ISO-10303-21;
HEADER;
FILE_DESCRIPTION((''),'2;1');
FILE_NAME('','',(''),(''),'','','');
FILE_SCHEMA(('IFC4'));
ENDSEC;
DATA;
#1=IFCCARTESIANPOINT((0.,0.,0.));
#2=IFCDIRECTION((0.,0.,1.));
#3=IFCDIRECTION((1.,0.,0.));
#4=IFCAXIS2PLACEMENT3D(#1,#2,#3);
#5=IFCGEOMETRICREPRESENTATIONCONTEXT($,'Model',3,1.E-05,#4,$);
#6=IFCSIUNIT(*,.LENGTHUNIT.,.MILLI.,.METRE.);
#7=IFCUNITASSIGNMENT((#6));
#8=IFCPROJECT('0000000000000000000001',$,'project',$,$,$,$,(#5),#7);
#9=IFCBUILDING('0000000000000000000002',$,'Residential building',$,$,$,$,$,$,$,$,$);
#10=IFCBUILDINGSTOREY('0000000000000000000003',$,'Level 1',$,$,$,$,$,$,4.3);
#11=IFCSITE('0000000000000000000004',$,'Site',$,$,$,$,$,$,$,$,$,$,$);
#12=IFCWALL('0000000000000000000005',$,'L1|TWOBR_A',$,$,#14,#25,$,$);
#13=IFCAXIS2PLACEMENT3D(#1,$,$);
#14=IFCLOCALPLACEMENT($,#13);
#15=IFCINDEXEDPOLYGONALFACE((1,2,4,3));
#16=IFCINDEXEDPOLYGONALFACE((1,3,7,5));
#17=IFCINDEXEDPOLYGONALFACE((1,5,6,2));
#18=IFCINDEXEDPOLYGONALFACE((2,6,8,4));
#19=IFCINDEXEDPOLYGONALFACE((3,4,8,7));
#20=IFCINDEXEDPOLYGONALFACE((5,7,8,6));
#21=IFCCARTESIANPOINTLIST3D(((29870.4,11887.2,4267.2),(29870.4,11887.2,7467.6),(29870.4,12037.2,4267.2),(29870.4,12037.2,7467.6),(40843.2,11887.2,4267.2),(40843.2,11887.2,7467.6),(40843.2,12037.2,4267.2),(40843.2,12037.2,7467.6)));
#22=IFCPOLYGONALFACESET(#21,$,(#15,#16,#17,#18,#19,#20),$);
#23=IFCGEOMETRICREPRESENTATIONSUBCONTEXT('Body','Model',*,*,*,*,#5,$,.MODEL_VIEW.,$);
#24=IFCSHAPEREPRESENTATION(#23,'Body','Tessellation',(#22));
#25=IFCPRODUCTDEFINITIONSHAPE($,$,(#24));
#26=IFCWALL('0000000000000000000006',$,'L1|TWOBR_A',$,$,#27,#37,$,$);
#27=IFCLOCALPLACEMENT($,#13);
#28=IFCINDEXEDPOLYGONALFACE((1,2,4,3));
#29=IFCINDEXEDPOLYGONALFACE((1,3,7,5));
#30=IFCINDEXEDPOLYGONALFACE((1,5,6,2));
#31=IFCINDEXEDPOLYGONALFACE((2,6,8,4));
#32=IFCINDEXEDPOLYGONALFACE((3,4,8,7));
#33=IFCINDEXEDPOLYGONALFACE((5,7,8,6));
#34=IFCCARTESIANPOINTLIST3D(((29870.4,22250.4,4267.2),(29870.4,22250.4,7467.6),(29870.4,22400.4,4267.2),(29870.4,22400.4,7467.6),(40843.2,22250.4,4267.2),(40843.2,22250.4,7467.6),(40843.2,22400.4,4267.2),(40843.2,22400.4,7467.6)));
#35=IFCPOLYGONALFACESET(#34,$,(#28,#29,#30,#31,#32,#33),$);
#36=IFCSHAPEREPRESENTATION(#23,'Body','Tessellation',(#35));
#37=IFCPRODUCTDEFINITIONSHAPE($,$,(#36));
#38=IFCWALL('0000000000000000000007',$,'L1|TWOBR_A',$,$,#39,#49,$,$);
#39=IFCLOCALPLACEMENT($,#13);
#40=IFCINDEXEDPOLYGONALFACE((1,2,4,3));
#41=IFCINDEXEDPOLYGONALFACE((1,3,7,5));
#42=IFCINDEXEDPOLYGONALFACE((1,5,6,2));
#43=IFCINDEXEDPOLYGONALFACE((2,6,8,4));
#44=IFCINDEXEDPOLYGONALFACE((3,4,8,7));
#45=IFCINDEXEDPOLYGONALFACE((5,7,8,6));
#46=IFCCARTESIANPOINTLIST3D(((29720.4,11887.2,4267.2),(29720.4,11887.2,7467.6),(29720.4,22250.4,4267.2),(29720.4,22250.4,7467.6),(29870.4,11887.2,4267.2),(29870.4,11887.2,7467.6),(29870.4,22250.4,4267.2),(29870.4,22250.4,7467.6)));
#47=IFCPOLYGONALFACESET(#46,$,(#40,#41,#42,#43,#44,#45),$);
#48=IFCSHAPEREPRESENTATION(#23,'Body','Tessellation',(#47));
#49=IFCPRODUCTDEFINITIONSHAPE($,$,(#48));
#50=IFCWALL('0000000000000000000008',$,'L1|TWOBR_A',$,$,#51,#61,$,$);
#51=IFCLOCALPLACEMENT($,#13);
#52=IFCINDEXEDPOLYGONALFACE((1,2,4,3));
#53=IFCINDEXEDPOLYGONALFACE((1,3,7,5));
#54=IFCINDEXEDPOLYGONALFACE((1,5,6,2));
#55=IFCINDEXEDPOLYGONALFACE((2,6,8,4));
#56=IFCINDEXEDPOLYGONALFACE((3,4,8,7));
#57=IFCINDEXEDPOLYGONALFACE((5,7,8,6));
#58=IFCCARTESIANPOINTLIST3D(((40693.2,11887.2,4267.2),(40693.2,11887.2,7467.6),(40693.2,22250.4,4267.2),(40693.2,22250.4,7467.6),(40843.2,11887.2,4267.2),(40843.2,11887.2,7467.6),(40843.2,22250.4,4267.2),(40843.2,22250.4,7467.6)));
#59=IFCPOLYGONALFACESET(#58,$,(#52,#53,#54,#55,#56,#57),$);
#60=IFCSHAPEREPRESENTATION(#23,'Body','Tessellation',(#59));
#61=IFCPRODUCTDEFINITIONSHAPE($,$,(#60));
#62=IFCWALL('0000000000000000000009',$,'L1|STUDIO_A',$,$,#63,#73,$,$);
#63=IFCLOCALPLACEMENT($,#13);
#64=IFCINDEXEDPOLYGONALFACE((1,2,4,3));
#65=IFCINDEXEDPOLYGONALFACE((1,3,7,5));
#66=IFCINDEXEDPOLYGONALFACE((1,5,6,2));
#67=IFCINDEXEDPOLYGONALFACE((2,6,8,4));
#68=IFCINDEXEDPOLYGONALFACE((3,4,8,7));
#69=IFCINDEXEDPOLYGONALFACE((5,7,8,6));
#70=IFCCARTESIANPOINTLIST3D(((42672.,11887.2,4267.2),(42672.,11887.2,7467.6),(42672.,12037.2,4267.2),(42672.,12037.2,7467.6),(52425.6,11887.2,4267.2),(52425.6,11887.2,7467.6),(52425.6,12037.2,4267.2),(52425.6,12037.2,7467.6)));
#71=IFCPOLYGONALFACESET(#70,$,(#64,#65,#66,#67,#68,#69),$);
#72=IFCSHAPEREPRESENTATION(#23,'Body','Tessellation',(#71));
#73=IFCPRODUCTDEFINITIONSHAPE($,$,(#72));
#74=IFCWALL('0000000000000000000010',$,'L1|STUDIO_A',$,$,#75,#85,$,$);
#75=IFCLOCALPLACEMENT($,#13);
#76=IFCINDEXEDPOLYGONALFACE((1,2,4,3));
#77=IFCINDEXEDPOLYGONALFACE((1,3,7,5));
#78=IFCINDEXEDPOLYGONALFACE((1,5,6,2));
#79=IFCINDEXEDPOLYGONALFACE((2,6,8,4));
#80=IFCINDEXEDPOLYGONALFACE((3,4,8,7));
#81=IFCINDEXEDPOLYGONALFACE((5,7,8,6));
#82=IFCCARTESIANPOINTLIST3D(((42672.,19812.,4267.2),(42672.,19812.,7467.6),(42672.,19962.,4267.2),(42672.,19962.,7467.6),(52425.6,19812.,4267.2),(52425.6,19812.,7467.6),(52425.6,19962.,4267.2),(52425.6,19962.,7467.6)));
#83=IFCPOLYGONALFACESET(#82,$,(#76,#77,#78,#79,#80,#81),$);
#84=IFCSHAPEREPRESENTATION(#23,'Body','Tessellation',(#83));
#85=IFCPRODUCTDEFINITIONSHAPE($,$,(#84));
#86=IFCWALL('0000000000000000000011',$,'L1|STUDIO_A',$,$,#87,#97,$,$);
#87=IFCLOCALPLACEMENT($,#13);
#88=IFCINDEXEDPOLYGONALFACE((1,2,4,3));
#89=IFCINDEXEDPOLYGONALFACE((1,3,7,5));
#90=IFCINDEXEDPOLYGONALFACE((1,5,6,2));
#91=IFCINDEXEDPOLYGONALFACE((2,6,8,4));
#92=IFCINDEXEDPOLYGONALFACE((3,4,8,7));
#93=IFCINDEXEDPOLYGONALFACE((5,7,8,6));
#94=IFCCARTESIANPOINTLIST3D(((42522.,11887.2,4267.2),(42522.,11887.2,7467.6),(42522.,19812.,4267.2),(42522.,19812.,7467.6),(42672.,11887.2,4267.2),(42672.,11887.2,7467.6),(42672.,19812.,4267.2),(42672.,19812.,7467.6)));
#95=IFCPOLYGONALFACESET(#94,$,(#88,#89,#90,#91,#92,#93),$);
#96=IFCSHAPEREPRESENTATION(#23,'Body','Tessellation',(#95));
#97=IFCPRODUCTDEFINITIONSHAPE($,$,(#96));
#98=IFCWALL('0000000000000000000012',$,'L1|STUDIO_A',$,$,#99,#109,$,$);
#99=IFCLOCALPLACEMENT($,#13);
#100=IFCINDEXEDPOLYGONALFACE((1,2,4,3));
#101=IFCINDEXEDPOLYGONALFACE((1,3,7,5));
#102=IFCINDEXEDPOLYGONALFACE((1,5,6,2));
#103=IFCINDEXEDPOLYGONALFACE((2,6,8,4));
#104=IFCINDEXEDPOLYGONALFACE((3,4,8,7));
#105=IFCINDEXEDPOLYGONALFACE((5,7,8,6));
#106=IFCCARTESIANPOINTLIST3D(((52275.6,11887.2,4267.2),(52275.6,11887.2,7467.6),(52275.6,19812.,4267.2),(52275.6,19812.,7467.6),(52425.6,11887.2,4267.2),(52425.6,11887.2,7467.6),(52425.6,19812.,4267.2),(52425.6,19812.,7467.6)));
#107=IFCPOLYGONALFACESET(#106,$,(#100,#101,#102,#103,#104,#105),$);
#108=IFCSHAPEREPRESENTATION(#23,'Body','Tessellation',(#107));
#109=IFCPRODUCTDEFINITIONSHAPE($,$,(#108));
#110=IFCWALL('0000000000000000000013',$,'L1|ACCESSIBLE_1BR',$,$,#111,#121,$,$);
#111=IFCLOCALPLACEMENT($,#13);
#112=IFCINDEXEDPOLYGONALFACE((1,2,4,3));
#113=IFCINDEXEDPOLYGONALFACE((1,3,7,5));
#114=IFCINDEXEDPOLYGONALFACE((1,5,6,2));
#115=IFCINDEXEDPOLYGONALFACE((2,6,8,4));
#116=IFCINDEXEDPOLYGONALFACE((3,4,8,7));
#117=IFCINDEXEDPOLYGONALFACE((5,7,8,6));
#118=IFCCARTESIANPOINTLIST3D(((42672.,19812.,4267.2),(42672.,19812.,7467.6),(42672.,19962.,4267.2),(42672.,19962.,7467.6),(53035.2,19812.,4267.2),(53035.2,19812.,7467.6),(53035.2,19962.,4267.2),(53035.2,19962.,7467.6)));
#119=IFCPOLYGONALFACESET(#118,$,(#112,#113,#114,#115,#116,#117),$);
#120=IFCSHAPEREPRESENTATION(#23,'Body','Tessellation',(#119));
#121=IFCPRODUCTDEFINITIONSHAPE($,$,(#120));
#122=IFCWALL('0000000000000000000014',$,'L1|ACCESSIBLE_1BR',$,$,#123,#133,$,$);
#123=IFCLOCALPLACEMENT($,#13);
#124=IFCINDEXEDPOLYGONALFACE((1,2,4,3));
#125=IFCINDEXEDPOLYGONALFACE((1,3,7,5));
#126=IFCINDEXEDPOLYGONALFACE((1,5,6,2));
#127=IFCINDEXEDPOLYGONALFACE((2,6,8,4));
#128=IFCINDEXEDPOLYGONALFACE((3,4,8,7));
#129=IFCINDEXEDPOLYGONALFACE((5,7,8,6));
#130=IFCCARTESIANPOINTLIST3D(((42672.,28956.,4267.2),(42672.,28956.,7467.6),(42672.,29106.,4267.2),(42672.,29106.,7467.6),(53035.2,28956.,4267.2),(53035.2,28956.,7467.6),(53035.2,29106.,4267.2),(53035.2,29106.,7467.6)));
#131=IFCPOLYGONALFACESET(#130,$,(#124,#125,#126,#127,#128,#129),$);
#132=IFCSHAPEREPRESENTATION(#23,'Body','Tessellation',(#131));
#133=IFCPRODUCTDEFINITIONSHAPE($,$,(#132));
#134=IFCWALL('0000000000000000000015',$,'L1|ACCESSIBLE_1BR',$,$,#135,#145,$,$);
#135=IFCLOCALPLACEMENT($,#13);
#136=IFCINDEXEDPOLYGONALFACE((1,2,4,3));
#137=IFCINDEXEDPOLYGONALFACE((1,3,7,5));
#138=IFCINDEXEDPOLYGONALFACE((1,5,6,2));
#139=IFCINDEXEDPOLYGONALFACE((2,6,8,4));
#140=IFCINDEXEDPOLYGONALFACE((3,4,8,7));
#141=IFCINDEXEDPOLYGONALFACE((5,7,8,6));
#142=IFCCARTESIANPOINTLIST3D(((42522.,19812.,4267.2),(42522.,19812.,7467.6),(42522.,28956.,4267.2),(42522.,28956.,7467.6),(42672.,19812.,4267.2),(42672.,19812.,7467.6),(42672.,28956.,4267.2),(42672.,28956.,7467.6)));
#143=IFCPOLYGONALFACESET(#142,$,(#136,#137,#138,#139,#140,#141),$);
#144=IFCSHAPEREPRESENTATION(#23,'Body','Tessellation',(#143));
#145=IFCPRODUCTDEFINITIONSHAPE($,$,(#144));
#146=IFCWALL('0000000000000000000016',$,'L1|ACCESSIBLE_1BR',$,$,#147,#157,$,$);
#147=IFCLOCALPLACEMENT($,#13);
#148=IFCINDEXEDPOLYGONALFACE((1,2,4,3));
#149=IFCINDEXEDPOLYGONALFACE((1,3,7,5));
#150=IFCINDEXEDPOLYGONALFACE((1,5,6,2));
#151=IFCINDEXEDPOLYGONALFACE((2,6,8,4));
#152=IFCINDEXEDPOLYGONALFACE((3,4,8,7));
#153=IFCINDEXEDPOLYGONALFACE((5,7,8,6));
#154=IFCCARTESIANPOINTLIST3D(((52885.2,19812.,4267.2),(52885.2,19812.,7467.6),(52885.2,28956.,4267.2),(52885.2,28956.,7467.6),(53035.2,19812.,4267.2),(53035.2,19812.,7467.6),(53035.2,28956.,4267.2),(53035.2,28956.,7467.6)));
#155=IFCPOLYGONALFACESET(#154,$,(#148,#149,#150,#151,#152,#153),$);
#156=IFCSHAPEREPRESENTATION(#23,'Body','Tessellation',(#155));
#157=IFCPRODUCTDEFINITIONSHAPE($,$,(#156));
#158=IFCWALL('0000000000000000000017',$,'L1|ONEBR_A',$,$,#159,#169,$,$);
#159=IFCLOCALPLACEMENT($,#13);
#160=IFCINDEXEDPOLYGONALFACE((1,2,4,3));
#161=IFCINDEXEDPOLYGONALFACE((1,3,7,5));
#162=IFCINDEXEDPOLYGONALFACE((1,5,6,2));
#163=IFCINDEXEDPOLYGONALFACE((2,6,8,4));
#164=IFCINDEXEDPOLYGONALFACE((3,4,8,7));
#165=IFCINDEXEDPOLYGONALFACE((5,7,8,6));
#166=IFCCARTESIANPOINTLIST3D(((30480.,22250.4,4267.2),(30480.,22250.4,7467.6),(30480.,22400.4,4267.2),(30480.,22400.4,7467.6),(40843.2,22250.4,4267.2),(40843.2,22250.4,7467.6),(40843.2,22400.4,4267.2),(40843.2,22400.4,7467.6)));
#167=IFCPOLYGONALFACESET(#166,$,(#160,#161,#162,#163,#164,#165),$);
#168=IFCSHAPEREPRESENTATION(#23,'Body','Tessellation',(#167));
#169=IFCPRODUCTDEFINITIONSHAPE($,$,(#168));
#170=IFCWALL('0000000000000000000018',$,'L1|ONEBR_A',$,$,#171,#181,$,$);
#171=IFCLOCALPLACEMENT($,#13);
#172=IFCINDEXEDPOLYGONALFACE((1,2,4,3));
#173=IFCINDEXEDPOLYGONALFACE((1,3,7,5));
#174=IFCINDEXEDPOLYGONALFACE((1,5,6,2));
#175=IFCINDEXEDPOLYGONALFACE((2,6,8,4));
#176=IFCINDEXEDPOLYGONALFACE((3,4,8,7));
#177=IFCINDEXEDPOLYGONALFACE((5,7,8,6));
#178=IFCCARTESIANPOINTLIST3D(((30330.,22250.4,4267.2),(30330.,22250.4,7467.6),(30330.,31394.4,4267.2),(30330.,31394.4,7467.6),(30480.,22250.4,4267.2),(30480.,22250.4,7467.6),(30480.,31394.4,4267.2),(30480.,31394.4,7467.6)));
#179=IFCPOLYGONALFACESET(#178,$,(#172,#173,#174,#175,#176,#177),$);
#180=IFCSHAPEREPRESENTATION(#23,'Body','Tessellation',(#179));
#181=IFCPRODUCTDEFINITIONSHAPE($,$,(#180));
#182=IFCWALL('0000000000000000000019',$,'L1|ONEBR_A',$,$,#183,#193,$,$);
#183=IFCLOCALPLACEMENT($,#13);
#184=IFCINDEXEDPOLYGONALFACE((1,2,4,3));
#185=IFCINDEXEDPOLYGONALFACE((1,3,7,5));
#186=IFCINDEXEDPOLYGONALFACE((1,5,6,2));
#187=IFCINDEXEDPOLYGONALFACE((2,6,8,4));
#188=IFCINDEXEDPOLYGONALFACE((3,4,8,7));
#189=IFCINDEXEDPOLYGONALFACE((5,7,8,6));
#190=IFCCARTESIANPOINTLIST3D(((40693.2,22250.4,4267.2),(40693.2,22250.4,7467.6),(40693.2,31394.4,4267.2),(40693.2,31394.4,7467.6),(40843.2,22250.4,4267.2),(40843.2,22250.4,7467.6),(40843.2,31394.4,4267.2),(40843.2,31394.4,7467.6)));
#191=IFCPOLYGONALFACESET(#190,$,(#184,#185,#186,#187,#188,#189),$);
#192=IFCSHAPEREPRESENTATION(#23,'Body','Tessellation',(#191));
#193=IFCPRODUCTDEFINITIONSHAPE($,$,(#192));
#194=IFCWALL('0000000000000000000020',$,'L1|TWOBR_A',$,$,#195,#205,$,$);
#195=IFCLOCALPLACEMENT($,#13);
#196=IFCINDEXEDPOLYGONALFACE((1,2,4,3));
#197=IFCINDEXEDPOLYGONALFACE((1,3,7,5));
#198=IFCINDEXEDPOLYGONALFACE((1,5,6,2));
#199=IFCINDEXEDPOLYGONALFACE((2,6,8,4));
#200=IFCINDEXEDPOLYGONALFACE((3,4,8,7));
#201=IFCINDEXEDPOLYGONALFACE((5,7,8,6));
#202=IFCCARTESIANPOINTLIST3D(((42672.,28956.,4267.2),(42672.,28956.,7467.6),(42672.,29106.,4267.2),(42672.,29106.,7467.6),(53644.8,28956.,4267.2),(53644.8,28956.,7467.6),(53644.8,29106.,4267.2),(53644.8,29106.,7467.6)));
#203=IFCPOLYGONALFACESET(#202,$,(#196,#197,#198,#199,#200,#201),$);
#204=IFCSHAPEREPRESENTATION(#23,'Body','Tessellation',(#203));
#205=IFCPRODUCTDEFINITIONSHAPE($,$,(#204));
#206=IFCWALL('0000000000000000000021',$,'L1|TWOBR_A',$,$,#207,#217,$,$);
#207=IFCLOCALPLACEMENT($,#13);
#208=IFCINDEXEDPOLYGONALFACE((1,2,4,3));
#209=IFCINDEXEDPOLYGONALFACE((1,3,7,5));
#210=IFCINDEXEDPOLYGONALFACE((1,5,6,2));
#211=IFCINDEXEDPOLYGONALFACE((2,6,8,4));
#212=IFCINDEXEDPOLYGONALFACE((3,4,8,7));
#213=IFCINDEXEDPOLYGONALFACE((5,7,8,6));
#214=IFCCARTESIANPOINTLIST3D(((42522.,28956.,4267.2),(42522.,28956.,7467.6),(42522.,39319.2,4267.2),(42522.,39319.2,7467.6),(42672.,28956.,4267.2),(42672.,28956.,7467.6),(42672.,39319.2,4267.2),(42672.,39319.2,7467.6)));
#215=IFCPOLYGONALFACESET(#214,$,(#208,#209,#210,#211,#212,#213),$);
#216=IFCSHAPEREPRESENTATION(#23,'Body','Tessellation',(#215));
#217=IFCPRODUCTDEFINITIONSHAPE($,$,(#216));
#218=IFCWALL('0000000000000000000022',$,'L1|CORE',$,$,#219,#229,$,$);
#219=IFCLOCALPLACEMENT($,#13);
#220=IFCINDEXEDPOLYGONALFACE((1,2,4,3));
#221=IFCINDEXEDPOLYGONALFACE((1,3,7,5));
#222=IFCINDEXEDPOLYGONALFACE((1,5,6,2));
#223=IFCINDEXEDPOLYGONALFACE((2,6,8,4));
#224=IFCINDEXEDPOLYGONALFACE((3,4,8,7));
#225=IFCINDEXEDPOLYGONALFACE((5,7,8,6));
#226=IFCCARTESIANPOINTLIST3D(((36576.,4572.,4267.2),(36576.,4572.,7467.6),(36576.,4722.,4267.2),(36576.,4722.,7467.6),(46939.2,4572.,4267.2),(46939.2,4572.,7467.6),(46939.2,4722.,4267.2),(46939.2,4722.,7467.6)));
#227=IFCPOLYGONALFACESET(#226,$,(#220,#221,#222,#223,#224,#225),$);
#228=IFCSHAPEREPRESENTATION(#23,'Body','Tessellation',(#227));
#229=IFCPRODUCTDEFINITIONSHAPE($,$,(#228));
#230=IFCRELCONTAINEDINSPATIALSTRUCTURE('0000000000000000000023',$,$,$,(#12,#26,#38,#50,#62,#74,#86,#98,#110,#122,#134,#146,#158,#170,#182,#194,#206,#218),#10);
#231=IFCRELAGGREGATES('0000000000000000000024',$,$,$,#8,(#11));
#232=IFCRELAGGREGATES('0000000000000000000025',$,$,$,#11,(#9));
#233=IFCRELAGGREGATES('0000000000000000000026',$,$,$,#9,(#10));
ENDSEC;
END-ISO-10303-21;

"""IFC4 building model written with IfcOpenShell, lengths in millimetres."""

from ifc_helpers import new_model, si_unit, frame, origin_with_axes, place, context, subcontext, project, spatial, indexed_curve, outline, extrude, element, save


model = new_model("IFC4")

# Units and contexts
model_context = context("Model", 3, precision=1e-05, world=origin_with_axes())
body_context = subcontext(model_context, "Body", "Model", "MODEL_VIEW")
ifc_project = project(units=[si_unit("LENGTHUNIT", "METRE", prefix="MILLI")], contexts=[model_context])

# Site, building, storey
site = spatial("IfcSite", under=ifc_project, Name="Site")
building = spatial("IfcBuilding", under=site, Name="Residential building")
storey = spatial("IfcBuildingStorey", under=building, Name="Level 1", Elevation=4.3)

# Walls
for number, where, z_axis, x_axis, name in (
    (1, (29870.4, 11887.2, 4267.2), (0.0, 0.0, 1.0), (1.0, 0.0, 0.0), "L1|TWOBR_A"),
    (2, (29870.4, 22250.4, 4267.2), (0.0, 0.0, 1.0), (1.0, 0.0, 0.0), "L1|TWOBR_A"),
):
    element("IfcWall", number, at=place(None, frame(where, z_axis=z_axis, x_axis=x_axis)), inside=storey, Name=name, context=body_context, shape_type="SweptSolid", body=[
        extrude(outline(indexed_curve([(0.0, 0.0), (0.0, 150.0), (10972.8, 150.0), (10972.8, 0.0), (0.0, 0.0)], self_intersect=False)), origin_with_axes(), (0.0, 0.0, 1.0), 3200.4),
    ])
for number, where, z_axis, x_axis, name in (
    (3, (29870.4, 11887.2, 4267.2), (0.0, 0.0, 1.0), (0.0, 1.0, 0.0), "L1|TWOBR_A"),
    (4, (40843.2, 11887.2, 4267.2), (0.0, 0.0, 1.0), (0.0, 1.0, 0.0), "L1|TWOBR_A"),
):
    element("IfcWall", number, at=place(None, frame(where, z_axis=z_axis, x_axis=x_axis)), inside=storey, Name=name, context=body_context, shape_type="SweptSolid", body=[
        extrude(outline(indexed_curve([(0.0, 0.0), (0.0, 150.0), (10363.2, 150.0), (10363.2, 0.0), (0.0, 0.0)], self_intersect=False)), origin_with_axes(), (0.0, 0.0, 1.0), 3200.4),
    ])
for number, where, z_axis, x_axis, name in (
    (5, (42672.0, 11887.2, 4267.2), (0.0, 0.0, 1.0), (1.0, 0.0, 0.0), "L1|STUDIO_A"),
    (6, (42672.0, 19812.0, 4267.2), (0.0, 0.0, 1.0), (1.0, 0.0, 0.0), "L1|STUDIO_A"),
):
    element("IfcWall", number, at=place(None, frame(where, z_axis=z_axis, x_axis=x_axis)), inside=storey, Name=name, context=body_context, shape_type="SweptSolid", body=[
        extrude(outline(indexed_curve([(0.0, 0.0), (0.0, 150.0), (9753.6, 150.0), (9753.6, 0.0), (0.0, 0.0)], self_intersect=False)), origin_with_axes(), (0.0, 0.0, 1.0), 3200.4),
    ])
for number, where, z_axis, x_axis, name in (
    (7, (42672.0, 11887.2, 4267.2), (0.0, 0.0, 1.0), (0.0, 1.0, 0.0), "L1|STUDIO_A"),
    (8, (52425.6, 11887.2, 4267.2), (0.0, 0.0, 1.0), (0.0, 1.0, 0.0), "L1|STUDIO_A"),
):
    element("IfcWall", number, at=place(None, frame(where, z_axis=z_axis, x_axis=x_axis)), inside=storey, Name=name, context=body_context, shape_type="SweptSolid", body=[
        extrude(outline(indexed_curve([(0.0, 0.0), (0.0, 150.0), (7924.8, 150.0), (7924.8, 0.0), (0.0, 0.0)], self_intersect=False)), origin_with_axes(), (0.0, 0.0, 1.0), 3200.4),
    ])
for number, where, z_axis, x_axis, name in (
    (9, (42672.0, 19812.0, 4267.2), (0.0, 0.0, 1.0), (1.0, 0.0, 0.0), "L1|ACCESSIBLE_1BR"),
    (10, (42672.0, 28956.0, 4267.2), (0.0, 0.0, 1.0), (1.0, 0.0, 0.0), "L1|ACCESSIBLE_1BR"),
):
    element("IfcWall", number, at=place(None, frame(where, z_axis=z_axis, x_axis=x_axis)), inside=storey, Name=name, context=body_context, shape_type="SweptSolid", body=[
        extrude(outline(indexed_curve([(0.0, 0.0), (0.0, 150.0), (10363.2, 150.0), (10363.2, 0.0), (0.0, 0.0)], self_intersect=False)), origin_with_axes(), (0.0, 0.0, 1.0), 3200.4),
    ])
for number, where, z_axis, x_axis, name in (
    (11, (42672.0, 19812.0, 4267.2), (0.0, 0.0, 1.0), (0.0, 1.0, 0.0), "L1|ACCESSIBLE_1BR"),
    (12, (53035.2, 19812.0, 4267.2), (0.0, 0.0, 1.0), (0.0, 1.0, 0.0), "L1|ACCESSIBLE_1BR"),
):
    element("IfcWall", number, at=place(None, frame(where, z_axis=z_axis, x_axis=x_axis)), inside=storey, Name=name, context=body_context, shape_type="SweptSolid", body=[
        extrude(outline(indexed_curve([(0.0, 0.0), (0.0, 150.0), (9144.0, 150.0), (9144.0, 0.0), (0.0, 0.0)], self_intersect=False)), origin_with_axes(), (0.0, 0.0, 1.0), 3200.4),
    ])
wall_1_placement = place(None, frame((30480.0, 22250.4, 4267.2), z_axis=(0.0, 0.0, 1.0), x_axis=(1.0, 0.0, 0.0)))
element("IfcWall", 13, at=wall_1_placement, inside=storey, Name="L1|ONEBR_A", context=body_context, shape_type="SweptSolid", body=[
    extrude(outline(indexed_curve([(0.0, 0.0), (0.0, 150.0), (10363.2, 150.0), (10363.2, 0.0), (0.0, 0.0)], self_intersect=False)), origin_with_axes(), (0.0, 0.0, 1.0), 3200.4),
])
for number, where, z_axis, x_axis, name in (
    (14, (30480.0, 22250.4, 4267.2), (0.0, 0.0, 1.0), (0.0, 1.0, 0.0), "L1|ONEBR_A"),
    (15, (40843.2, 22250.4, 4267.2), (0.0, 0.0, 1.0), (0.0, 1.0, 0.0), "L1|ONEBR_A"),
):
    element("IfcWall", number, at=place(None, frame(where, z_axis=z_axis, x_axis=x_axis)), inside=storey, Name=name, context=body_context, shape_type="SweptSolid", body=[
        extrude(outline(indexed_curve([(0.0, 0.0), (0.0, 150.0), (9144.0, 150.0), (9144.0, 0.0), (0.0, 0.0)], self_intersect=False)), origin_with_axes(), (0.0, 0.0, 1.0), 3200.4),
    ])
wall_2_placement = place(None, frame((42672.0, 28956.0, 4267.2), z_axis=(0.0, 0.0, 1.0), x_axis=(1.0, 0.0, 0.0)))
element("IfcWall", 16, at=wall_2_placement, inside=storey, Name="L1|TWOBR_A", context=body_context, shape_type="SweptSolid", body=[
    extrude(outline(indexed_curve([(0.0, 0.0), (0.0, 150.0), (10972.8, 150.0), (10972.8, 0.0), (0.0, 0.0)], self_intersect=False)), origin_with_axes(), (0.0, 0.0, 1.0), 3200.4),
])
for number, where, z_axis, x_axis, name in (
    (17, (42672.0, 28956.0, 4267.2), (0.0, 0.0, 1.0), (0.0, 1.0, 0.0), "L1|TWOBR_A"),
    (18, (36576.0, 4572.0, 4267.2), (0.0, 0.0, 1.0), (1.0, 0.0, 0.0), "L1|CORE"),
):
    element("IfcWall", number, at=place(None, frame(where, z_axis=z_axis, x_axis=x_axis)), inside=storey, Name=name, context=body_context, shape_type="SweptSolid", body=[
        extrude(outline(indexed_curve([(0.0, 0.0), (0.0, 150.0), (10363.2, 150.0), (10363.2, 0.0), (0.0, 0.0)], self_intersect=False)), origin_with_axes(), (0.0, 0.0, 1.0), 3200.4),
    ])

save(model, "model.ifc")
